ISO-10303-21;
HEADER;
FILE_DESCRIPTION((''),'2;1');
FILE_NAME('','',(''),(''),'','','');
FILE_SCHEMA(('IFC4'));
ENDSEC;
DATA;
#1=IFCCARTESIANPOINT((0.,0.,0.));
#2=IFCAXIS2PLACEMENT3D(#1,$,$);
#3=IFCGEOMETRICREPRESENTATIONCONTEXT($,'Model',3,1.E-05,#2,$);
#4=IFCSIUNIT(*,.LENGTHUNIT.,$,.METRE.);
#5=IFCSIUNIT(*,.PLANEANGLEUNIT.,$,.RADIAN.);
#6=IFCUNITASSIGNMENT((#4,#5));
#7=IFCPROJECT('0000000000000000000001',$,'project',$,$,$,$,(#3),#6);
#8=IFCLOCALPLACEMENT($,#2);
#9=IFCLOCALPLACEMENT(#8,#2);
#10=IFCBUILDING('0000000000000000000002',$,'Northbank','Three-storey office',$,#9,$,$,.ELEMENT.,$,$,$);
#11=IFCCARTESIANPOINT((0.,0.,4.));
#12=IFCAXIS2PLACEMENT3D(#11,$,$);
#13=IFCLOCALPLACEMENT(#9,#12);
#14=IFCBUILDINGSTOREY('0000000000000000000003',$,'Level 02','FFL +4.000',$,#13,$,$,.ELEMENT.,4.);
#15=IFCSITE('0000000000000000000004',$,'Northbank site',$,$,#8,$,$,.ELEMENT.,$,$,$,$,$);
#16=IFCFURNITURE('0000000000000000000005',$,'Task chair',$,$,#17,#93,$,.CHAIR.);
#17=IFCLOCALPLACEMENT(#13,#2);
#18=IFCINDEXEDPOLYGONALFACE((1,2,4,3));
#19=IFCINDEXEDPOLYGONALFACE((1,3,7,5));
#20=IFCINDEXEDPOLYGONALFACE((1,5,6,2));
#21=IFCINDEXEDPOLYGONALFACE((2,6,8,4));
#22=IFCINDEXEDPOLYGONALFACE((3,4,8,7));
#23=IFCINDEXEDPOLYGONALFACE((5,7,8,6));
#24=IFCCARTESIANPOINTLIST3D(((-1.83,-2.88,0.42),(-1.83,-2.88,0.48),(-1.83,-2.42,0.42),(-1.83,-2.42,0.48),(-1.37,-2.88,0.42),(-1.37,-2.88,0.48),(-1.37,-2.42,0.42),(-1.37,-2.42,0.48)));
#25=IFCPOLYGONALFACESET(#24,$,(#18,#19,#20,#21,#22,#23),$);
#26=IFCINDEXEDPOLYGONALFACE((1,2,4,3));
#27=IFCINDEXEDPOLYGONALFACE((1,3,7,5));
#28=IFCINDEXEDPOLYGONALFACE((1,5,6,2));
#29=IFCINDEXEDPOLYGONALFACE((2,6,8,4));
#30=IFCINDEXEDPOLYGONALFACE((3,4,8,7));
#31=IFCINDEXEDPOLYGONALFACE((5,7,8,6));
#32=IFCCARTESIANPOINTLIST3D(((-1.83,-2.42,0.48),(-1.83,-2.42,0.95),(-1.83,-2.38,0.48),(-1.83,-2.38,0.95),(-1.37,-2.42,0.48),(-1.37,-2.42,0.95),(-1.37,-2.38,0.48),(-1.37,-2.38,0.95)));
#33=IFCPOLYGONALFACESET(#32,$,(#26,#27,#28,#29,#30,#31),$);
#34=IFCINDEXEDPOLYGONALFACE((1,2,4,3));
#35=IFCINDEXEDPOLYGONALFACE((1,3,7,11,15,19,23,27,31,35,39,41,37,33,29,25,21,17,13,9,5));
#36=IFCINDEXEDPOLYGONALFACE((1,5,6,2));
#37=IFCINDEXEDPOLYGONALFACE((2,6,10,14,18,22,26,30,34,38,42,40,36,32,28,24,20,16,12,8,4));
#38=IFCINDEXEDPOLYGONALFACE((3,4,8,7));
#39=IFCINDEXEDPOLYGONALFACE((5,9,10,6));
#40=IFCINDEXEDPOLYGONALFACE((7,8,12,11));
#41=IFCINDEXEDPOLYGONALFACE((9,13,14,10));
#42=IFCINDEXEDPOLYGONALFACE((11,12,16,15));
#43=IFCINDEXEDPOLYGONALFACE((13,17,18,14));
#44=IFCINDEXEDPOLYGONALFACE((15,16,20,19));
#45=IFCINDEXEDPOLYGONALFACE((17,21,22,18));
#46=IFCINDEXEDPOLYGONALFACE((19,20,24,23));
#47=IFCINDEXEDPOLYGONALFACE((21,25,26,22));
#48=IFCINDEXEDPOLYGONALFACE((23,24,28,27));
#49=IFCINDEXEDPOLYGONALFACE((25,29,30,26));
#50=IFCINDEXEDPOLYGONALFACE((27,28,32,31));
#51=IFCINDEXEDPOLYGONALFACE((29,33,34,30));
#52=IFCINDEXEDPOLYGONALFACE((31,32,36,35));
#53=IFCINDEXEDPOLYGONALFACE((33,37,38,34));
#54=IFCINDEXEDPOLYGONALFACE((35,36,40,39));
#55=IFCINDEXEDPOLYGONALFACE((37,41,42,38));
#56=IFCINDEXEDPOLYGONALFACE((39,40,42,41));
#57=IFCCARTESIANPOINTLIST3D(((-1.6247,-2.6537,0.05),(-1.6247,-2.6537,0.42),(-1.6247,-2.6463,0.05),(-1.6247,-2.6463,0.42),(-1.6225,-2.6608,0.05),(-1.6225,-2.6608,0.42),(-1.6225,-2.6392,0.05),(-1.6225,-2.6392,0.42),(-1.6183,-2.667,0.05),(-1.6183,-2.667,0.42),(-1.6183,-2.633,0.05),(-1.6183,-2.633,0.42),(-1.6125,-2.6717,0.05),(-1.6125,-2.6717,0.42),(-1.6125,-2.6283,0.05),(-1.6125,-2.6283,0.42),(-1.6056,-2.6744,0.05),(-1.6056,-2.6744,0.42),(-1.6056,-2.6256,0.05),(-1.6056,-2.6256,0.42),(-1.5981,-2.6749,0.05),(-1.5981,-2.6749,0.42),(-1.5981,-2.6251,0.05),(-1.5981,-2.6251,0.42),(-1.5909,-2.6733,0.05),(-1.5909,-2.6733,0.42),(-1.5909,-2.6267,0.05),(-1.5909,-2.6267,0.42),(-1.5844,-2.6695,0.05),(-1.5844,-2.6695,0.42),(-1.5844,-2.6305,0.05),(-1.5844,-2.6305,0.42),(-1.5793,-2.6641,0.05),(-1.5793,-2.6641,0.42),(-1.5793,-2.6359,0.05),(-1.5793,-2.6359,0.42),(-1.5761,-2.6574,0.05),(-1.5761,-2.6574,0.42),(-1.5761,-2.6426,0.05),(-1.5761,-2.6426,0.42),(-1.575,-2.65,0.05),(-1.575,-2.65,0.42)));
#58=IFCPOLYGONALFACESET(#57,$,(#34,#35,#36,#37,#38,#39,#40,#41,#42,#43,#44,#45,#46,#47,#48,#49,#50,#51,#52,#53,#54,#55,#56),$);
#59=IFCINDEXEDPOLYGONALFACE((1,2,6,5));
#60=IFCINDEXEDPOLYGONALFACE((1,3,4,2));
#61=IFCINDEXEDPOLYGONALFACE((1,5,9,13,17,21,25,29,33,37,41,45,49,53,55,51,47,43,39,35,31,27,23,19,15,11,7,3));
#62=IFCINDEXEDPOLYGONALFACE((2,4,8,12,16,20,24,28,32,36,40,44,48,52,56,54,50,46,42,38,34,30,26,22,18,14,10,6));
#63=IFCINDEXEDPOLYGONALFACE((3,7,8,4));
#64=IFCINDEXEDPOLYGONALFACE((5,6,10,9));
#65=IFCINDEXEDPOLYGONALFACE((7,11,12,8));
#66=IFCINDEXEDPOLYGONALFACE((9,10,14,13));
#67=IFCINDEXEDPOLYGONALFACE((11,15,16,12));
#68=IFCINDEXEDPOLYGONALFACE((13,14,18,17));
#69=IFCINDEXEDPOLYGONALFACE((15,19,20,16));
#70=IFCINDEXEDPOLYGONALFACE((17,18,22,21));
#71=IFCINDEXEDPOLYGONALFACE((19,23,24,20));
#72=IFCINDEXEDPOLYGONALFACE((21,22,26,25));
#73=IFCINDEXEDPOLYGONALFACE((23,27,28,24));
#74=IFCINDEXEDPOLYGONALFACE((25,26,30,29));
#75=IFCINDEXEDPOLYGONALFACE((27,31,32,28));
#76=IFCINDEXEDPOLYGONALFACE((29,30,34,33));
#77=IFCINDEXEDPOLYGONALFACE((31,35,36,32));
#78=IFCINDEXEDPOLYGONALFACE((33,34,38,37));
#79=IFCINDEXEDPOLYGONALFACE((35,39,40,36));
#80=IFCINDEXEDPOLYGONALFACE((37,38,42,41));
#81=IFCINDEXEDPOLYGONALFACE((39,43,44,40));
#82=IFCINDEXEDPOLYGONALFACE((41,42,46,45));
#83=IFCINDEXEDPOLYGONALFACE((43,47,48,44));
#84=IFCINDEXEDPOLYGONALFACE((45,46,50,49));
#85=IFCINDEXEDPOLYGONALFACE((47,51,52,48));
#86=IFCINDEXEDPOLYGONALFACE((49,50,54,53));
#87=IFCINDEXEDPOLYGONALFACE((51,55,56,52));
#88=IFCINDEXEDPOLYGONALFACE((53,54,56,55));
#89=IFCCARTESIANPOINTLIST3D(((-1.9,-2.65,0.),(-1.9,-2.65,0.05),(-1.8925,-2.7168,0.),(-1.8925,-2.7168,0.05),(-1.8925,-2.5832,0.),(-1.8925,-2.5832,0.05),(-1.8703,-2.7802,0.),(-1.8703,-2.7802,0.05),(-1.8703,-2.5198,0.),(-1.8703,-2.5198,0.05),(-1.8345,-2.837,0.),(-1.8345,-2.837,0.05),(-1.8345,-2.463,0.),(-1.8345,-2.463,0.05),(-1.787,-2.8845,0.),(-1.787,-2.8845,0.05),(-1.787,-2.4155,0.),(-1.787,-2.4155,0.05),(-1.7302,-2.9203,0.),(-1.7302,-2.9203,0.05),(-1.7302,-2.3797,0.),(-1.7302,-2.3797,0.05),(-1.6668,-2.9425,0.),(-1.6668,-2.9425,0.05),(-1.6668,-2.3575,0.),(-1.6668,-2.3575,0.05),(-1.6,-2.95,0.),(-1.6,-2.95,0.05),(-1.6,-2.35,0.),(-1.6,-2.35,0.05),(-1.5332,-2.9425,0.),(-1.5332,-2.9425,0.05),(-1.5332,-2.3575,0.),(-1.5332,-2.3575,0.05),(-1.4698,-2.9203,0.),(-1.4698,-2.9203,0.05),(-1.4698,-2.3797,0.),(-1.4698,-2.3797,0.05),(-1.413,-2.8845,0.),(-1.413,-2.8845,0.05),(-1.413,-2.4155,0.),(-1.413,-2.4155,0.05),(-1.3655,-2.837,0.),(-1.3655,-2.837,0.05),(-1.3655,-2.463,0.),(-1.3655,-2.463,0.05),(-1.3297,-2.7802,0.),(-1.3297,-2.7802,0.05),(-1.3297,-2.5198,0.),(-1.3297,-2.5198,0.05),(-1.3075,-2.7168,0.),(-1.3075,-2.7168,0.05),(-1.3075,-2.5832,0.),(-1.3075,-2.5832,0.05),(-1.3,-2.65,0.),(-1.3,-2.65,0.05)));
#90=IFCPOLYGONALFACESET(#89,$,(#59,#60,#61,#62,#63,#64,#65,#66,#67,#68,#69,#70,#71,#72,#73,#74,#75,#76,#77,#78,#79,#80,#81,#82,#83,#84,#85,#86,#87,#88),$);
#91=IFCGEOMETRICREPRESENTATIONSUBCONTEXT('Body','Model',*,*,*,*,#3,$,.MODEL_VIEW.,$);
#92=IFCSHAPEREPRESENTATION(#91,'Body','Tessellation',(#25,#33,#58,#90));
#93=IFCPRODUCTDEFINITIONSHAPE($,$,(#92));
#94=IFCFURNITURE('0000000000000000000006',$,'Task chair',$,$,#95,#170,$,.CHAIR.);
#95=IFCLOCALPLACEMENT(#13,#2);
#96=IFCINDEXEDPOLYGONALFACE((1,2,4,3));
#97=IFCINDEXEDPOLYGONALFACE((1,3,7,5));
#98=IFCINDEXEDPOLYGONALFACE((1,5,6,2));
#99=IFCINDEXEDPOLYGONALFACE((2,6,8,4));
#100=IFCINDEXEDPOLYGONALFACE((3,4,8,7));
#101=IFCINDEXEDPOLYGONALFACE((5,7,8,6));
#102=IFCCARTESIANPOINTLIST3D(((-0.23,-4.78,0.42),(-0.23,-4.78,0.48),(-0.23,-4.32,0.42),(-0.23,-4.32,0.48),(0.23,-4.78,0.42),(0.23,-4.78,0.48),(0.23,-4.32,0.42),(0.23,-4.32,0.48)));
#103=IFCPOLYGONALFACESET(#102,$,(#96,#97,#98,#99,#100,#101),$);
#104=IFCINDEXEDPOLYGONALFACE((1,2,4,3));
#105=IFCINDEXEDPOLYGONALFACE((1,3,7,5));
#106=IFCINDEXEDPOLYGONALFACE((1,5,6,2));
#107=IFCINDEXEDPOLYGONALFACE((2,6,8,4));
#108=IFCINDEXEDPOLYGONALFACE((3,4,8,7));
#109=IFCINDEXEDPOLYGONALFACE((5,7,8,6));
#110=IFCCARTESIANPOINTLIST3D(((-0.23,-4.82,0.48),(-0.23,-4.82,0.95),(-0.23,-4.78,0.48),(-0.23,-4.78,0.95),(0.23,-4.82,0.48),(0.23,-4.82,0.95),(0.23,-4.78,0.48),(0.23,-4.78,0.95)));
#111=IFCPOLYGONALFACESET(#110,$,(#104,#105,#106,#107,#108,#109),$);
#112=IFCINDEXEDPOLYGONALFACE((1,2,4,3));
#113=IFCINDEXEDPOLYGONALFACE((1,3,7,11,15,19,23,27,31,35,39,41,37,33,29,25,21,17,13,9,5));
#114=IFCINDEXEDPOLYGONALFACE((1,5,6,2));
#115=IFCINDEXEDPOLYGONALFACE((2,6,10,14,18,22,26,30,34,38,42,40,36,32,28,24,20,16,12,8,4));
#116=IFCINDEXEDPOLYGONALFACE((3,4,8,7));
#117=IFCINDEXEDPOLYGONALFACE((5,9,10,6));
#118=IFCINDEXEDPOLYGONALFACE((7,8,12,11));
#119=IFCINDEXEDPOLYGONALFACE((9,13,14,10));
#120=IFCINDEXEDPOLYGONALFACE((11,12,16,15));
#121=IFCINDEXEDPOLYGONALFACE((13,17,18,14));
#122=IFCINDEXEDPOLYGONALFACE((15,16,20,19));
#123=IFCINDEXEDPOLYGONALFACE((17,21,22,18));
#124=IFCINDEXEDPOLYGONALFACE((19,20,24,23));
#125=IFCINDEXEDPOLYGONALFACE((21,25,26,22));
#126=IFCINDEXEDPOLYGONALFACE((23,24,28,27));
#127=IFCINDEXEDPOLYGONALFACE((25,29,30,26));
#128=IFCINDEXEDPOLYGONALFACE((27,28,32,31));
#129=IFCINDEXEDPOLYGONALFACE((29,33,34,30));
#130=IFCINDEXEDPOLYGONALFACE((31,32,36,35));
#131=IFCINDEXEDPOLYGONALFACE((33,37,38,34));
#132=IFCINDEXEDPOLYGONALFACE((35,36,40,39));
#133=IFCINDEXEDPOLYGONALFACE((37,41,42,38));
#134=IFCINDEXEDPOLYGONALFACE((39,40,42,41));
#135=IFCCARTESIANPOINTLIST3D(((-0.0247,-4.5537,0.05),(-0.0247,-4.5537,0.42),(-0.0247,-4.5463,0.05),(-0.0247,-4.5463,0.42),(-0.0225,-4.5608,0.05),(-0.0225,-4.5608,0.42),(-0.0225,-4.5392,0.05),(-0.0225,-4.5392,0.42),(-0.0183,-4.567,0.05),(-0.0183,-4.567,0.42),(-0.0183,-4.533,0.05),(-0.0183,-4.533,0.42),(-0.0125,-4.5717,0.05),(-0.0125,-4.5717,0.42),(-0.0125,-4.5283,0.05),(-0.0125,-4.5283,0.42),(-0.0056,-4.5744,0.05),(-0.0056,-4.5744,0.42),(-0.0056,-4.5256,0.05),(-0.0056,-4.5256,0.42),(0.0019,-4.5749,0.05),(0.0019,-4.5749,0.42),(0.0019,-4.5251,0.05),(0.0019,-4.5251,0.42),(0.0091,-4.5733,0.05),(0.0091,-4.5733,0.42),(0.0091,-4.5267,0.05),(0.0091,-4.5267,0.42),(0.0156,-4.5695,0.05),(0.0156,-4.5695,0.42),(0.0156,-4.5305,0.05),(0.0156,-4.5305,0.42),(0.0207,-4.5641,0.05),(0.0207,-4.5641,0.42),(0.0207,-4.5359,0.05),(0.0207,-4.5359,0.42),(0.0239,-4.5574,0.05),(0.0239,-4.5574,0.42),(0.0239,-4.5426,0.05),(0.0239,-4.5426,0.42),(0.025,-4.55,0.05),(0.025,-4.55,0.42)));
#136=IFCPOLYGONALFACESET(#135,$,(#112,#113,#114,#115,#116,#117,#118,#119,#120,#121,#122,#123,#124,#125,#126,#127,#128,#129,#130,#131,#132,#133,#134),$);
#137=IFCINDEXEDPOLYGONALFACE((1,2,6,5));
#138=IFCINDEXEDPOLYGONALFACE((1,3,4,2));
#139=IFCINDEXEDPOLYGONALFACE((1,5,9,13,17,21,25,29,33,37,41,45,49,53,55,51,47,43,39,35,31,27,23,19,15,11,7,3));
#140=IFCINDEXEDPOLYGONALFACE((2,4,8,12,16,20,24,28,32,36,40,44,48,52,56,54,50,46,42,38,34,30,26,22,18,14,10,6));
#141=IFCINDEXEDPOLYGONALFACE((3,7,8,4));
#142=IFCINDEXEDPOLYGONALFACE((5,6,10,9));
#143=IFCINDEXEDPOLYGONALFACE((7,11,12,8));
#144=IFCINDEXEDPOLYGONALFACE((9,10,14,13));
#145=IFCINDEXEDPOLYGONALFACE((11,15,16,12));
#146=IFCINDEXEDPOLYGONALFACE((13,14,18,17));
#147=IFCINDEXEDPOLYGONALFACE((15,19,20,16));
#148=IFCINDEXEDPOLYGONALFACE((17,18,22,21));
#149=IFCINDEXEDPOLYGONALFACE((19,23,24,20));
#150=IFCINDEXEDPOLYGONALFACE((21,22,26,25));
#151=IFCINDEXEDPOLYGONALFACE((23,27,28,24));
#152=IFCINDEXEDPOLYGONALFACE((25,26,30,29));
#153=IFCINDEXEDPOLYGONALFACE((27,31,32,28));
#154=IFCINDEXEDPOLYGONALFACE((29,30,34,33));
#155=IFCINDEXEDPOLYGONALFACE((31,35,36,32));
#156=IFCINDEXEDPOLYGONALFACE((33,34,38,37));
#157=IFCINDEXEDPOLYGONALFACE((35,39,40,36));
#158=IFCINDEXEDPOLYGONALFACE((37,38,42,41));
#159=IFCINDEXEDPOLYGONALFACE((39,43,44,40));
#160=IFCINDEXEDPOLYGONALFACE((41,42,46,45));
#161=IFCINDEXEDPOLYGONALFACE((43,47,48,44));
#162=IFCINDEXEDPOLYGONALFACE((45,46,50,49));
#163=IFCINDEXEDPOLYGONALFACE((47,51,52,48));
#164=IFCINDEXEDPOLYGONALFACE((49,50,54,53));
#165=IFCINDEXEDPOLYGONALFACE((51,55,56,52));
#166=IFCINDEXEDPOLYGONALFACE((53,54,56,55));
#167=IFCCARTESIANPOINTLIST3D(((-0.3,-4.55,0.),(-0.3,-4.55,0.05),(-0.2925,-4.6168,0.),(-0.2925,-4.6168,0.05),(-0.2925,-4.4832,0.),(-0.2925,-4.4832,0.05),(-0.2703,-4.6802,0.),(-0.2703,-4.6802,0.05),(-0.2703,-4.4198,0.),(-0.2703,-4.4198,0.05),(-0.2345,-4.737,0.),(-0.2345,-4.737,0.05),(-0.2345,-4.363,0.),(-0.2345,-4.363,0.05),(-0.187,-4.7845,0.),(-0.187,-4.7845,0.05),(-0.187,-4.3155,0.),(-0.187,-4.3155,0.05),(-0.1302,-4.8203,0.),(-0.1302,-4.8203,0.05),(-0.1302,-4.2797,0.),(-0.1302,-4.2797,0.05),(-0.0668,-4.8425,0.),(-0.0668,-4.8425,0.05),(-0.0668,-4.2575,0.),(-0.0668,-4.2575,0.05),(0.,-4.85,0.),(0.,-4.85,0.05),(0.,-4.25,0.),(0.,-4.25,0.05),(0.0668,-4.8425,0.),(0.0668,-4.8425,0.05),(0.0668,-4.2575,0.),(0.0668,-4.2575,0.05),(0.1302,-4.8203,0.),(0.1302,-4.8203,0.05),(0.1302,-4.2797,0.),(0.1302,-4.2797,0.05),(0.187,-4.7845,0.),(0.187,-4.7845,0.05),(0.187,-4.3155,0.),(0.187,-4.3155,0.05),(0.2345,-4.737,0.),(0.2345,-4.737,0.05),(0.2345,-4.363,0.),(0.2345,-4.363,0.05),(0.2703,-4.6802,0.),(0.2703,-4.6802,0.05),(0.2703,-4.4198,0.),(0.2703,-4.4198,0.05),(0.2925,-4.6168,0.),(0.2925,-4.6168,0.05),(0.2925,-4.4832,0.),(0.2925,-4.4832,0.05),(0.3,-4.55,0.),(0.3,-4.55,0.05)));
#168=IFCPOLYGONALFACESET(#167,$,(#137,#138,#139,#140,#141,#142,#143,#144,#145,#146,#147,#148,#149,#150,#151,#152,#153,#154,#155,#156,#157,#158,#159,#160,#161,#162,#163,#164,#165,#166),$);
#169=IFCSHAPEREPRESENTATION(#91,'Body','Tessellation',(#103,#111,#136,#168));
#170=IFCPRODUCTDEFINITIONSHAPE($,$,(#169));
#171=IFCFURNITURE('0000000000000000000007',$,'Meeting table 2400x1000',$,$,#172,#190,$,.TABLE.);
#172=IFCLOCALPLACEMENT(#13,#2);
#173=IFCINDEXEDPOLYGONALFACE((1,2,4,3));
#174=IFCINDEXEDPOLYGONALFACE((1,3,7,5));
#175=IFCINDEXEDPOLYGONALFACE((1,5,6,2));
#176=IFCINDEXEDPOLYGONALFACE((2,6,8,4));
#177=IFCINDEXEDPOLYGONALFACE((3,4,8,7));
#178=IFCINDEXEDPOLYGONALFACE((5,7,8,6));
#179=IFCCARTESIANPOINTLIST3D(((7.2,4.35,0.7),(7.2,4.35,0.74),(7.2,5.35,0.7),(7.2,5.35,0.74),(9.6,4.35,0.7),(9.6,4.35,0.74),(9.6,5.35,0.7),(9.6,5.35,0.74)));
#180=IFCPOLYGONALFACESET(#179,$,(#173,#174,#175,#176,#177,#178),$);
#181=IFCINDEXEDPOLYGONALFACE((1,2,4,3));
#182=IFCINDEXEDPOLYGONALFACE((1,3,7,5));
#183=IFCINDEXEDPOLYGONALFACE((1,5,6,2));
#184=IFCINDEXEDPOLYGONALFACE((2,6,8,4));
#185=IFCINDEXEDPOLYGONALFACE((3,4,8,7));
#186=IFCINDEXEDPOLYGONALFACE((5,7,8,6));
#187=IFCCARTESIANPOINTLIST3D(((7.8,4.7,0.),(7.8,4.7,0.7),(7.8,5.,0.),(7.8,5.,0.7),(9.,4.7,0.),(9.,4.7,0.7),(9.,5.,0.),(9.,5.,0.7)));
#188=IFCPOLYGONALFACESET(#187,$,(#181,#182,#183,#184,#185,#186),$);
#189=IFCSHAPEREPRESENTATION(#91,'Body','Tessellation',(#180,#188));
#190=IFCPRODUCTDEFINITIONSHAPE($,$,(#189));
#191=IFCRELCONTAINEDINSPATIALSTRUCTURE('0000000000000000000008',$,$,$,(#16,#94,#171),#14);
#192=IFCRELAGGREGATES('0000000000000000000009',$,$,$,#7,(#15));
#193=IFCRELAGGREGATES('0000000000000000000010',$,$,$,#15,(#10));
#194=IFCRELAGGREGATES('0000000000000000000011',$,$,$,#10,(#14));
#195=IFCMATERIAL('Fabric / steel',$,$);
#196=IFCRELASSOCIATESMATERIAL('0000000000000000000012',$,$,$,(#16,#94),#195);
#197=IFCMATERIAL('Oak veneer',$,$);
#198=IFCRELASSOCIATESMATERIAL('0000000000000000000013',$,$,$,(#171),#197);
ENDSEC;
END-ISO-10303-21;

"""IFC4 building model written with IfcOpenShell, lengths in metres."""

from ifc_helpers import new_model, si_unit, frame, origin, place, context, subcontext, project, spatial, rectangle, circle, extrude, material, element, save


model = new_model("IFC4")

# Units and contexts
model_context = context("Model", 3, precision=1e-05, world=origin())
body_context = subcontext(model_context, "Body", "Model", "MODEL_VIEW")
ifc_project = project(units=[si_unit("LENGTHUNIT", "METRE"), si_unit("PLANEANGLEUNIT", "RADIAN")], contexts=[model_context])

# Site, building, storey
site_placement = place(None, origin())
site = spatial("IfcSite", under=ifc_project, at=site_placement, Name="Northbank site", CompositionType="ELEMENT")
building_placement = place(site_placement, origin())
building = spatial("IfcBuilding", under=site, at=building_placement, Name="Northbank", Description="Three-storey office", CompositionType="ELEMENT")
storey_placement = place(building_placement, frame((0.0, 0.0, 4.0)))
storey = spatial("IfcBuildingStorey", under=building, at=storey_placement, Name="Level 02", Description="FFL +4.000", CompositionType="ELEMENT", Elevation=4.0)

# Furniture
ifc_material_1 = material(Name="Fabric / steel")
furniture_1_placement = place(storey_placement, frame((0.0, 0.0, -4.0)))
element("IfcFurniture", 1, at=furniture_1_placement, inside=storey, material=ifc_material_1, Name="Task chair", PredefinedType="CHAIR", context=body_context, shape_type="SweptSolid", body=[
    extrude(rectangle(XDim=0.46, YDim=0.46), frame((-1.6, -2.65, 4.42)), (0.0, 0.0, 1.0), 0.06),
    extrude(rectangle(XDim=0.46, YDim=0.04), frame((-1.6, -2.4, 4.48)), (0.0, 0.0, 1.0), 0.47),
    extrude(circle(Radius=0.025), frame((-1.6, -2.65, 4.05), z_axis=(0.0, 0.0, 1.0), x_axis=(1.0, 0.0, 0.0)), (0.0, 0.0, 1.0), 0.37),
    extrude(circle(Radius=0.3), frame((-1.6, -2.65, 4.0), z_axis=(0.0, 0.0, 1.0), x_axis=(1.0, 0.0, 0.0)), (0.0, 0.0, 1.0), 0.05),
])
furniture_2_placement = place(storey_placement, frame((0.0, 0.0, -4.0)))
element("IfcFurniture", 2, at=furniture_2_placement, inside=storey, material=ifc_material_1, Name="Task chair", PredefinedType="CHAIR", context=body_context, shape_type="SweptSolid", body=[
    extrude(rectangle(XDim=0.46, YDim=0.46), frame((0.0, -4.55, 4.42)), (0.0, 0.0, 1.0), 0.06),
    extrude(rectangle(XDim=0.46, YDim=0.04), frame((0.0, -4.8, 4.48)), (0.0, 0.0, 1.0), 0.47),
    extrude(circle(Radius=0.025), frame((0.0, -4.55, 4.05), z_axis=(0.0, 0.0, 1.0), x_axis=(1.0, 0.0, 0.0)), (0.0, 0.0, 1.0), 0.37),
    extrude(circle(Radius=0.3), frame((0.0, -4.55, 4.0), z_axis=(0.0, 0.0, 1.0), x_axis=(1.0, 0.0, 0.0)), (0.0, 0.0, 1.0), 0.05),
])
ifc_material_2 = material(Name="Oak veneer")
furniture_3_placement = place(storey_placement, frame((0.0, 0.0, -4.0)))
element("IfcFurniture", 3, at=furniture_3_placement, inside=storey, material=ifc_material_2, Name="Meeting table 2400x1000", PredefinedType="TABLE", context=body_context, shape_type="SweptSolid", body=[
    extrude(rectangle(XDim=2.4, YDim=1.0), frame((8.4, 4.85, 4.7)), (0.0, 0.0, 1.0), 0.04),
    extrude(rectangle(XDim=1.2, YDim=0.3), frame((8.4, 4.85, 4.0)), (0.0, 0.0, 1.0), 0.7),
])

save(model, "model.ifc")
